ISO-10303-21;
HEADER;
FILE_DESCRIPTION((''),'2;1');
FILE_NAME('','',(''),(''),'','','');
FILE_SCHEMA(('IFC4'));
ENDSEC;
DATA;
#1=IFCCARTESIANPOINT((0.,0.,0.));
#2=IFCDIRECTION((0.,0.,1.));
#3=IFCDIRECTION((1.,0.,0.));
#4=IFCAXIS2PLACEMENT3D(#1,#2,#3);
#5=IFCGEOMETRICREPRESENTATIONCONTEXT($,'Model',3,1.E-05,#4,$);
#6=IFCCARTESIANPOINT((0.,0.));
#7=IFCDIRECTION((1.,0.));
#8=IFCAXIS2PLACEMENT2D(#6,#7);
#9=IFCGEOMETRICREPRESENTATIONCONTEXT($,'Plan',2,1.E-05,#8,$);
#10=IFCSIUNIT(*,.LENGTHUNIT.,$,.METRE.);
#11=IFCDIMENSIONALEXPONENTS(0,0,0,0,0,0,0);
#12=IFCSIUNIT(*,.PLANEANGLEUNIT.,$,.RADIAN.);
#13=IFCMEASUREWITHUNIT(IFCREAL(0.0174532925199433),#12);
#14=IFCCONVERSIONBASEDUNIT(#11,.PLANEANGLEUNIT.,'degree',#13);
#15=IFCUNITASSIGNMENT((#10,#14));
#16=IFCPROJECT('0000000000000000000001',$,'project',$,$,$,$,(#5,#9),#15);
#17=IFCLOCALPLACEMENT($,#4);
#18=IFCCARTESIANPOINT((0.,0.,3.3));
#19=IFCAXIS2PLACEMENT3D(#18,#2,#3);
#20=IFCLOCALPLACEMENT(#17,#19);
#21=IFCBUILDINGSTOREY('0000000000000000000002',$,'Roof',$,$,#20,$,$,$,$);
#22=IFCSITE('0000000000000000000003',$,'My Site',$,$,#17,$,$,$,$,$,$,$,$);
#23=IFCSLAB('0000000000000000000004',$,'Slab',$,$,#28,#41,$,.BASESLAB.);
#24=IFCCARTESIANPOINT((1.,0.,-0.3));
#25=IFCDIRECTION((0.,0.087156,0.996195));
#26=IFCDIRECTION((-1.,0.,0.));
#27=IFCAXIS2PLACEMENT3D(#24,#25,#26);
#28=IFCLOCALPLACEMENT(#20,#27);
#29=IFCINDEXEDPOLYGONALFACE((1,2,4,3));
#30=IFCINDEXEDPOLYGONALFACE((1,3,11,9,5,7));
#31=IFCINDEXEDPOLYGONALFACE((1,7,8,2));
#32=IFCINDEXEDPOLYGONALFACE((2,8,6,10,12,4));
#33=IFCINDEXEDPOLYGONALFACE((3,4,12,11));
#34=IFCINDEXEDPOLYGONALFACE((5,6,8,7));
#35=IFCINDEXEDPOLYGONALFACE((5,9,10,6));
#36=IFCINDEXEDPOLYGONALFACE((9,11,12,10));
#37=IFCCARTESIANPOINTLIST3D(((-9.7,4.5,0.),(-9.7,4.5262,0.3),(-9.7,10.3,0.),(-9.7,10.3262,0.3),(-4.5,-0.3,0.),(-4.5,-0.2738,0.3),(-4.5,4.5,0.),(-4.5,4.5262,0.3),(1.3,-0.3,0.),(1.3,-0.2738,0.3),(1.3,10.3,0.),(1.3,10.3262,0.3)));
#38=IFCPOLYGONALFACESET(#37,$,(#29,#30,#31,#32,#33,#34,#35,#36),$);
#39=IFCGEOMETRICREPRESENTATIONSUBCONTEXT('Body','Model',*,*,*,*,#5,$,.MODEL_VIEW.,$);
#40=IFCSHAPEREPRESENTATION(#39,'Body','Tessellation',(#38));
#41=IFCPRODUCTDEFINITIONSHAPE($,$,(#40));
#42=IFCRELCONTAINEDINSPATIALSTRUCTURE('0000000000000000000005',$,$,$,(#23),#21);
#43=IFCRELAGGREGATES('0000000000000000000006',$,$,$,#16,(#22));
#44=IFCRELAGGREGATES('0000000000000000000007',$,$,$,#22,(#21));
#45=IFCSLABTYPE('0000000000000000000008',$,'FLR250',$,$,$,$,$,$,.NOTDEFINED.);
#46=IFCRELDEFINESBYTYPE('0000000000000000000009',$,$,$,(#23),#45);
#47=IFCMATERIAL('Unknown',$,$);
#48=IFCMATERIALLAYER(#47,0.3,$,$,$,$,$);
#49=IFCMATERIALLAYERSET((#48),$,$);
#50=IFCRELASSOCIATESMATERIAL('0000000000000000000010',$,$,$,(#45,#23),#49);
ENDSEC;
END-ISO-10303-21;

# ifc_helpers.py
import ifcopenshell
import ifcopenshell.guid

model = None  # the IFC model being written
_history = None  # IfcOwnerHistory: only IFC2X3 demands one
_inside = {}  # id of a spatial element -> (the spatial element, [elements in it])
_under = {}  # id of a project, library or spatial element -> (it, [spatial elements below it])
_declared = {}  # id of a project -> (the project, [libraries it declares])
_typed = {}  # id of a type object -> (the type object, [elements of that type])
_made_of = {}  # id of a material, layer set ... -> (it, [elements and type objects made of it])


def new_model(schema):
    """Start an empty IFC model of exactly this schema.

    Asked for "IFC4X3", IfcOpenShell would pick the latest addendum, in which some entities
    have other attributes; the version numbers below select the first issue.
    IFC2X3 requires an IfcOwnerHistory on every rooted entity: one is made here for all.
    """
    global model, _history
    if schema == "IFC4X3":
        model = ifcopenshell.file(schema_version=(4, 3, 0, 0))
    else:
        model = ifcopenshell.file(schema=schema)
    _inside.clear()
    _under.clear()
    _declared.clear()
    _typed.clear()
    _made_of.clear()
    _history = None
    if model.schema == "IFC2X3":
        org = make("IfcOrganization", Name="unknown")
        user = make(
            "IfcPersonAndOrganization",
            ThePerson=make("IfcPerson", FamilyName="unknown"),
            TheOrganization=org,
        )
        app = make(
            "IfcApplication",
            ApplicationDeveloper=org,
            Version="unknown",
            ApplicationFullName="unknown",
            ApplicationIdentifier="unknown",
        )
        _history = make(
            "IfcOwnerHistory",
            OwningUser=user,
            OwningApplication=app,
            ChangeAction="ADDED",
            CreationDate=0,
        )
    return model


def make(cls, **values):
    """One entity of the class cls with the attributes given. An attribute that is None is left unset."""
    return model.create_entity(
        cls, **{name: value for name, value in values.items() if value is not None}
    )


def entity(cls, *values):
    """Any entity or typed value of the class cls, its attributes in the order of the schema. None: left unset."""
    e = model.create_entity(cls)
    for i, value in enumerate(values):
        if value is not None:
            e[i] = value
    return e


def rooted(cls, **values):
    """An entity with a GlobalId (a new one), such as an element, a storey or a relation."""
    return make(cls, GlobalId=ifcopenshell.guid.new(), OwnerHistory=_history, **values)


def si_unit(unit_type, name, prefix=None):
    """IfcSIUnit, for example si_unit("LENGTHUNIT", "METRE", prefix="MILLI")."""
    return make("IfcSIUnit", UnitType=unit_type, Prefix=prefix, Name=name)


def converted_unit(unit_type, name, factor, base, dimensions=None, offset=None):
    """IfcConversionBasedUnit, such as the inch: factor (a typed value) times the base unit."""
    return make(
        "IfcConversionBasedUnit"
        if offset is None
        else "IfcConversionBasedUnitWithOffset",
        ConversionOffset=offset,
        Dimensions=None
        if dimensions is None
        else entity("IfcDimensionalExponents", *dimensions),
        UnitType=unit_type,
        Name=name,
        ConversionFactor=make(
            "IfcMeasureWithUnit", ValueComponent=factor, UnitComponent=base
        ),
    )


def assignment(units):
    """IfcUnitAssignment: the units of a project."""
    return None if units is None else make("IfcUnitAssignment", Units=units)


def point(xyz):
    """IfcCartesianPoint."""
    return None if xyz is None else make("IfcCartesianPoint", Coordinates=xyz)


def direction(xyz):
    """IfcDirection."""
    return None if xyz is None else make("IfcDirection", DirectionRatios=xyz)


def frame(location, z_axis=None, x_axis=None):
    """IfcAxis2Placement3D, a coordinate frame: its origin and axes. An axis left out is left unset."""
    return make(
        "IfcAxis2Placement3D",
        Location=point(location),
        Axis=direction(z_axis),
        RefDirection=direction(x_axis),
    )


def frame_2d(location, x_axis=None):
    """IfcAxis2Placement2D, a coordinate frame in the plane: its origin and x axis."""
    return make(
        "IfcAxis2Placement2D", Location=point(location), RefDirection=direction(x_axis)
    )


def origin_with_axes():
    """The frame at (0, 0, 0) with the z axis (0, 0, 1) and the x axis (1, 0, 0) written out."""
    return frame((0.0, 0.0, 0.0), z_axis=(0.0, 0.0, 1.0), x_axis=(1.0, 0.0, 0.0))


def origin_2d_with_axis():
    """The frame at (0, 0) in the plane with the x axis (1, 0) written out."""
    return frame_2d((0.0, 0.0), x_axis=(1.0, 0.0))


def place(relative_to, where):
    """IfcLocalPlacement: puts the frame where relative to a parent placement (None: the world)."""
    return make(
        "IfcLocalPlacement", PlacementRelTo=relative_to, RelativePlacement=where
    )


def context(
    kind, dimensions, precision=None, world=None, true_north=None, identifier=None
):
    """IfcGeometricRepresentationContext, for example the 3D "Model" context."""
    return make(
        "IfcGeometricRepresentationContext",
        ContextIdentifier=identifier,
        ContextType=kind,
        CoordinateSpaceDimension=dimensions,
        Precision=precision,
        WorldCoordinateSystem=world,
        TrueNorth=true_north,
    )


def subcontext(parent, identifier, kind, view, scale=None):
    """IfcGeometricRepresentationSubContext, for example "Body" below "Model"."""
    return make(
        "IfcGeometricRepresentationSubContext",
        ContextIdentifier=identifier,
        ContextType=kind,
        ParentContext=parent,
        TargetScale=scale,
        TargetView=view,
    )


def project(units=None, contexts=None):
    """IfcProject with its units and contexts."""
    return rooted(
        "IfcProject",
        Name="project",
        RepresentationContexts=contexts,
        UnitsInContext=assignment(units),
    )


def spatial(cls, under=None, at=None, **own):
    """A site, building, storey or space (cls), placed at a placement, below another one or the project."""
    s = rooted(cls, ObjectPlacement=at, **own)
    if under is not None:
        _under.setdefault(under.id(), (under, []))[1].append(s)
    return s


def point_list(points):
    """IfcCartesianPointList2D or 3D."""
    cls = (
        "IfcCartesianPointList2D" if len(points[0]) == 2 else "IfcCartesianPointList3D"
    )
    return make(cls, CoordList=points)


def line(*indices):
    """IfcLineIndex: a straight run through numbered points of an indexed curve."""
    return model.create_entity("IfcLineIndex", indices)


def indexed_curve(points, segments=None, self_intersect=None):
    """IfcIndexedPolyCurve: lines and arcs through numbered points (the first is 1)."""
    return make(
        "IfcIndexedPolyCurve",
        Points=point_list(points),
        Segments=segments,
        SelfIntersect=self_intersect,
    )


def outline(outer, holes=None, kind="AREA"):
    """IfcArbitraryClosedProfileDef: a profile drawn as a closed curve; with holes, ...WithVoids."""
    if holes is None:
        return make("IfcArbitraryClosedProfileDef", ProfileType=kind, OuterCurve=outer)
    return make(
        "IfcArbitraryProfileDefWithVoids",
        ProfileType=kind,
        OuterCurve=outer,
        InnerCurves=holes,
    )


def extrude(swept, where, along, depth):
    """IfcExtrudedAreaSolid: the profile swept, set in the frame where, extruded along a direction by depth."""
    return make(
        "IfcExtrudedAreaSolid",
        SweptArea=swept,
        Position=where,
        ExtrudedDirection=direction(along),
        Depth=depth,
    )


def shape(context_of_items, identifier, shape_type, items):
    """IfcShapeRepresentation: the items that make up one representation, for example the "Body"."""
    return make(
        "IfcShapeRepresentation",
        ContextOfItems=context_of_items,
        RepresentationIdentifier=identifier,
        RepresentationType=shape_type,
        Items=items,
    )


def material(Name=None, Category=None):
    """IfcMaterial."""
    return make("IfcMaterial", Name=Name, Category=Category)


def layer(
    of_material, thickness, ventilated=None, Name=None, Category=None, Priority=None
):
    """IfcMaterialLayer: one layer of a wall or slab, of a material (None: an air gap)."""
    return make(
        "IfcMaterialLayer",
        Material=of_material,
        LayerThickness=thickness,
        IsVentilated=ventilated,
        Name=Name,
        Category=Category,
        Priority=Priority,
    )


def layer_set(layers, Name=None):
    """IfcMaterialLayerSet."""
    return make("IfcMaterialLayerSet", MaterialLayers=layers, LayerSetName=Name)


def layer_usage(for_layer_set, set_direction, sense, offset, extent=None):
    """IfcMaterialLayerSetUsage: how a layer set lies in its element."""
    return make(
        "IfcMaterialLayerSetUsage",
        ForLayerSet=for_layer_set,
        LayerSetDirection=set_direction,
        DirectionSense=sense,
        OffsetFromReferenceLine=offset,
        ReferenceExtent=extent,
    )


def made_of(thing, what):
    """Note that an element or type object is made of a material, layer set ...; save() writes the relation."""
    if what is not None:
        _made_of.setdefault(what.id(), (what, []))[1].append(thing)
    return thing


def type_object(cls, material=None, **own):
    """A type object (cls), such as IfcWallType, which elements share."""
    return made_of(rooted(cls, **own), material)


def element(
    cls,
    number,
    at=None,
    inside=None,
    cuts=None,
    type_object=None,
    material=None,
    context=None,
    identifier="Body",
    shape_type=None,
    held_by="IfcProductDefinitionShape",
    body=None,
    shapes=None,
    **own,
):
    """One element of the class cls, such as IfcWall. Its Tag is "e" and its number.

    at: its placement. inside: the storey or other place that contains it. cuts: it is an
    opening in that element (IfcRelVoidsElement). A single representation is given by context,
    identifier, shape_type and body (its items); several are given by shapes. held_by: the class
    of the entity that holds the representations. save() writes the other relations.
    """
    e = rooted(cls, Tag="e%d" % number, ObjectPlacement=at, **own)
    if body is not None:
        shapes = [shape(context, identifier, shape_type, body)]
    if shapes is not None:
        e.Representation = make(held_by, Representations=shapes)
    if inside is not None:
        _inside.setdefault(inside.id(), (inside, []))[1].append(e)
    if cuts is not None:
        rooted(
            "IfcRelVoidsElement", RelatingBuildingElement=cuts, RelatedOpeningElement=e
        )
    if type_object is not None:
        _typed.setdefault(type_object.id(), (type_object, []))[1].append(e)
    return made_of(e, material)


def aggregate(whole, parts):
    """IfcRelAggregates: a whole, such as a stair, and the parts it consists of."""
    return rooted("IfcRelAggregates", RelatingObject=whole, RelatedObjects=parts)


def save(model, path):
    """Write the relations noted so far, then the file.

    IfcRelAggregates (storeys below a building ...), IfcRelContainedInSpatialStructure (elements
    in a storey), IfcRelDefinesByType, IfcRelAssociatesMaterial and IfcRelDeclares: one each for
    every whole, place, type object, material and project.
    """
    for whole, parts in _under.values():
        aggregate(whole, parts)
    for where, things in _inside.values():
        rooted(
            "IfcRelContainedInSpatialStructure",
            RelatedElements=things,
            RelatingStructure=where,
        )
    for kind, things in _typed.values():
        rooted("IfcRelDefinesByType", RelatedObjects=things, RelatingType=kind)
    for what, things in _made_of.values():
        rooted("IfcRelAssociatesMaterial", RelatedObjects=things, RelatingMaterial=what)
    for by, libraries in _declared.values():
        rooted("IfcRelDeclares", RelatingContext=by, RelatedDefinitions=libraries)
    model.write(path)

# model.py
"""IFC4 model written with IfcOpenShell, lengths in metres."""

from ifc_helpers import new_model, entity, si_unit, converted_unit, frame, origin_with_axes, origin_2d_with_axis, place, context, subcontext, project, spatial, line, indexed_curve, outline, extrude, material, layer, layer_set, layer_usage, type_object, element, save


model = new_model("IFC4")

# Units and contexts
model_context = context("Model", 3, precision=1e-05, world=origin_with_axes())
plan_context = context("Plan", 2, precision=1e-05, world=origin_2d_with_axis())
body_context = subcontext(model_context, "Body", "Model", "MODEL_VIEW")
ifc_project = project(units=[si_unit("LENGTHUNIT", "METRE"), converted_unit("PLANEANGLEUNIT", "degree", entity("IfcReal", 0.0174532925199433), si_unit("PLANEANGLEUNIT", "RADIAN"), dimensions=[0, 0, 0, 0, 0, 0, 0])], contexts=[model_context, plan_context])

# Site, storey
site_placement = place(None, origin_with_axes())
site = spatial("IfcSite", under=ifc_project, at=site_placement, Name="My Site")
storey_placement = place(site_placement, frame((0.0, 0.0, 3.3), z_axis=(0.0, 0.0, 1.0), x_axis=(1.0, 0.0, 0.0)))
storey = spatial("IfcBuildingStorey", under=site, at=storey_placement, Name="Roof")

# Slab
ifc_material = material(Name="Unknown")
ifc_layer = layer(ifc_material, 0.3)
ifc_layer_set = layer_set([ifc_layer])
ifc_layer_usage = layer_usage(ifc_layer_set, "AXIS3", "POSITIVE", 0.0)
slab_type = type_object("IfcSlabType", Name="FLR250", PredefinedType="NOTDEFINED", material=ifc_layer_set)
slab_placement = place(storey_placement, frame((1.0, 0.0, -0.3), z_axis=(0.0, 0.087156, 0.996195), x_axis=(-1.0, 0.0, 0.0)))
element("IfcSlab", 1, at=slab_placement, inside=storey, type_object=slab_type, material=ifc_layer_usage, Name="Slab", PredefinedType="BASESLAB", context=body_context, shape_type="SweptSolid", body=[
    extrude(outline(indexed_curve([(-9.7, 4.5), (-9.7, 10.3), (1.3, 10.3), (1.3, -0.3), (-4.5, -0.3), (-4.5, 4.5)], segments=[line(4, 3), line(3, 2), line(2, 1), line(1, 6), line(6, 5), line(5, 4)], self_intersect=False)), origin_with_axes(), (0.0, 0.087156, 0.996195), 0.3011),
])

save(model, "model.ifc")
